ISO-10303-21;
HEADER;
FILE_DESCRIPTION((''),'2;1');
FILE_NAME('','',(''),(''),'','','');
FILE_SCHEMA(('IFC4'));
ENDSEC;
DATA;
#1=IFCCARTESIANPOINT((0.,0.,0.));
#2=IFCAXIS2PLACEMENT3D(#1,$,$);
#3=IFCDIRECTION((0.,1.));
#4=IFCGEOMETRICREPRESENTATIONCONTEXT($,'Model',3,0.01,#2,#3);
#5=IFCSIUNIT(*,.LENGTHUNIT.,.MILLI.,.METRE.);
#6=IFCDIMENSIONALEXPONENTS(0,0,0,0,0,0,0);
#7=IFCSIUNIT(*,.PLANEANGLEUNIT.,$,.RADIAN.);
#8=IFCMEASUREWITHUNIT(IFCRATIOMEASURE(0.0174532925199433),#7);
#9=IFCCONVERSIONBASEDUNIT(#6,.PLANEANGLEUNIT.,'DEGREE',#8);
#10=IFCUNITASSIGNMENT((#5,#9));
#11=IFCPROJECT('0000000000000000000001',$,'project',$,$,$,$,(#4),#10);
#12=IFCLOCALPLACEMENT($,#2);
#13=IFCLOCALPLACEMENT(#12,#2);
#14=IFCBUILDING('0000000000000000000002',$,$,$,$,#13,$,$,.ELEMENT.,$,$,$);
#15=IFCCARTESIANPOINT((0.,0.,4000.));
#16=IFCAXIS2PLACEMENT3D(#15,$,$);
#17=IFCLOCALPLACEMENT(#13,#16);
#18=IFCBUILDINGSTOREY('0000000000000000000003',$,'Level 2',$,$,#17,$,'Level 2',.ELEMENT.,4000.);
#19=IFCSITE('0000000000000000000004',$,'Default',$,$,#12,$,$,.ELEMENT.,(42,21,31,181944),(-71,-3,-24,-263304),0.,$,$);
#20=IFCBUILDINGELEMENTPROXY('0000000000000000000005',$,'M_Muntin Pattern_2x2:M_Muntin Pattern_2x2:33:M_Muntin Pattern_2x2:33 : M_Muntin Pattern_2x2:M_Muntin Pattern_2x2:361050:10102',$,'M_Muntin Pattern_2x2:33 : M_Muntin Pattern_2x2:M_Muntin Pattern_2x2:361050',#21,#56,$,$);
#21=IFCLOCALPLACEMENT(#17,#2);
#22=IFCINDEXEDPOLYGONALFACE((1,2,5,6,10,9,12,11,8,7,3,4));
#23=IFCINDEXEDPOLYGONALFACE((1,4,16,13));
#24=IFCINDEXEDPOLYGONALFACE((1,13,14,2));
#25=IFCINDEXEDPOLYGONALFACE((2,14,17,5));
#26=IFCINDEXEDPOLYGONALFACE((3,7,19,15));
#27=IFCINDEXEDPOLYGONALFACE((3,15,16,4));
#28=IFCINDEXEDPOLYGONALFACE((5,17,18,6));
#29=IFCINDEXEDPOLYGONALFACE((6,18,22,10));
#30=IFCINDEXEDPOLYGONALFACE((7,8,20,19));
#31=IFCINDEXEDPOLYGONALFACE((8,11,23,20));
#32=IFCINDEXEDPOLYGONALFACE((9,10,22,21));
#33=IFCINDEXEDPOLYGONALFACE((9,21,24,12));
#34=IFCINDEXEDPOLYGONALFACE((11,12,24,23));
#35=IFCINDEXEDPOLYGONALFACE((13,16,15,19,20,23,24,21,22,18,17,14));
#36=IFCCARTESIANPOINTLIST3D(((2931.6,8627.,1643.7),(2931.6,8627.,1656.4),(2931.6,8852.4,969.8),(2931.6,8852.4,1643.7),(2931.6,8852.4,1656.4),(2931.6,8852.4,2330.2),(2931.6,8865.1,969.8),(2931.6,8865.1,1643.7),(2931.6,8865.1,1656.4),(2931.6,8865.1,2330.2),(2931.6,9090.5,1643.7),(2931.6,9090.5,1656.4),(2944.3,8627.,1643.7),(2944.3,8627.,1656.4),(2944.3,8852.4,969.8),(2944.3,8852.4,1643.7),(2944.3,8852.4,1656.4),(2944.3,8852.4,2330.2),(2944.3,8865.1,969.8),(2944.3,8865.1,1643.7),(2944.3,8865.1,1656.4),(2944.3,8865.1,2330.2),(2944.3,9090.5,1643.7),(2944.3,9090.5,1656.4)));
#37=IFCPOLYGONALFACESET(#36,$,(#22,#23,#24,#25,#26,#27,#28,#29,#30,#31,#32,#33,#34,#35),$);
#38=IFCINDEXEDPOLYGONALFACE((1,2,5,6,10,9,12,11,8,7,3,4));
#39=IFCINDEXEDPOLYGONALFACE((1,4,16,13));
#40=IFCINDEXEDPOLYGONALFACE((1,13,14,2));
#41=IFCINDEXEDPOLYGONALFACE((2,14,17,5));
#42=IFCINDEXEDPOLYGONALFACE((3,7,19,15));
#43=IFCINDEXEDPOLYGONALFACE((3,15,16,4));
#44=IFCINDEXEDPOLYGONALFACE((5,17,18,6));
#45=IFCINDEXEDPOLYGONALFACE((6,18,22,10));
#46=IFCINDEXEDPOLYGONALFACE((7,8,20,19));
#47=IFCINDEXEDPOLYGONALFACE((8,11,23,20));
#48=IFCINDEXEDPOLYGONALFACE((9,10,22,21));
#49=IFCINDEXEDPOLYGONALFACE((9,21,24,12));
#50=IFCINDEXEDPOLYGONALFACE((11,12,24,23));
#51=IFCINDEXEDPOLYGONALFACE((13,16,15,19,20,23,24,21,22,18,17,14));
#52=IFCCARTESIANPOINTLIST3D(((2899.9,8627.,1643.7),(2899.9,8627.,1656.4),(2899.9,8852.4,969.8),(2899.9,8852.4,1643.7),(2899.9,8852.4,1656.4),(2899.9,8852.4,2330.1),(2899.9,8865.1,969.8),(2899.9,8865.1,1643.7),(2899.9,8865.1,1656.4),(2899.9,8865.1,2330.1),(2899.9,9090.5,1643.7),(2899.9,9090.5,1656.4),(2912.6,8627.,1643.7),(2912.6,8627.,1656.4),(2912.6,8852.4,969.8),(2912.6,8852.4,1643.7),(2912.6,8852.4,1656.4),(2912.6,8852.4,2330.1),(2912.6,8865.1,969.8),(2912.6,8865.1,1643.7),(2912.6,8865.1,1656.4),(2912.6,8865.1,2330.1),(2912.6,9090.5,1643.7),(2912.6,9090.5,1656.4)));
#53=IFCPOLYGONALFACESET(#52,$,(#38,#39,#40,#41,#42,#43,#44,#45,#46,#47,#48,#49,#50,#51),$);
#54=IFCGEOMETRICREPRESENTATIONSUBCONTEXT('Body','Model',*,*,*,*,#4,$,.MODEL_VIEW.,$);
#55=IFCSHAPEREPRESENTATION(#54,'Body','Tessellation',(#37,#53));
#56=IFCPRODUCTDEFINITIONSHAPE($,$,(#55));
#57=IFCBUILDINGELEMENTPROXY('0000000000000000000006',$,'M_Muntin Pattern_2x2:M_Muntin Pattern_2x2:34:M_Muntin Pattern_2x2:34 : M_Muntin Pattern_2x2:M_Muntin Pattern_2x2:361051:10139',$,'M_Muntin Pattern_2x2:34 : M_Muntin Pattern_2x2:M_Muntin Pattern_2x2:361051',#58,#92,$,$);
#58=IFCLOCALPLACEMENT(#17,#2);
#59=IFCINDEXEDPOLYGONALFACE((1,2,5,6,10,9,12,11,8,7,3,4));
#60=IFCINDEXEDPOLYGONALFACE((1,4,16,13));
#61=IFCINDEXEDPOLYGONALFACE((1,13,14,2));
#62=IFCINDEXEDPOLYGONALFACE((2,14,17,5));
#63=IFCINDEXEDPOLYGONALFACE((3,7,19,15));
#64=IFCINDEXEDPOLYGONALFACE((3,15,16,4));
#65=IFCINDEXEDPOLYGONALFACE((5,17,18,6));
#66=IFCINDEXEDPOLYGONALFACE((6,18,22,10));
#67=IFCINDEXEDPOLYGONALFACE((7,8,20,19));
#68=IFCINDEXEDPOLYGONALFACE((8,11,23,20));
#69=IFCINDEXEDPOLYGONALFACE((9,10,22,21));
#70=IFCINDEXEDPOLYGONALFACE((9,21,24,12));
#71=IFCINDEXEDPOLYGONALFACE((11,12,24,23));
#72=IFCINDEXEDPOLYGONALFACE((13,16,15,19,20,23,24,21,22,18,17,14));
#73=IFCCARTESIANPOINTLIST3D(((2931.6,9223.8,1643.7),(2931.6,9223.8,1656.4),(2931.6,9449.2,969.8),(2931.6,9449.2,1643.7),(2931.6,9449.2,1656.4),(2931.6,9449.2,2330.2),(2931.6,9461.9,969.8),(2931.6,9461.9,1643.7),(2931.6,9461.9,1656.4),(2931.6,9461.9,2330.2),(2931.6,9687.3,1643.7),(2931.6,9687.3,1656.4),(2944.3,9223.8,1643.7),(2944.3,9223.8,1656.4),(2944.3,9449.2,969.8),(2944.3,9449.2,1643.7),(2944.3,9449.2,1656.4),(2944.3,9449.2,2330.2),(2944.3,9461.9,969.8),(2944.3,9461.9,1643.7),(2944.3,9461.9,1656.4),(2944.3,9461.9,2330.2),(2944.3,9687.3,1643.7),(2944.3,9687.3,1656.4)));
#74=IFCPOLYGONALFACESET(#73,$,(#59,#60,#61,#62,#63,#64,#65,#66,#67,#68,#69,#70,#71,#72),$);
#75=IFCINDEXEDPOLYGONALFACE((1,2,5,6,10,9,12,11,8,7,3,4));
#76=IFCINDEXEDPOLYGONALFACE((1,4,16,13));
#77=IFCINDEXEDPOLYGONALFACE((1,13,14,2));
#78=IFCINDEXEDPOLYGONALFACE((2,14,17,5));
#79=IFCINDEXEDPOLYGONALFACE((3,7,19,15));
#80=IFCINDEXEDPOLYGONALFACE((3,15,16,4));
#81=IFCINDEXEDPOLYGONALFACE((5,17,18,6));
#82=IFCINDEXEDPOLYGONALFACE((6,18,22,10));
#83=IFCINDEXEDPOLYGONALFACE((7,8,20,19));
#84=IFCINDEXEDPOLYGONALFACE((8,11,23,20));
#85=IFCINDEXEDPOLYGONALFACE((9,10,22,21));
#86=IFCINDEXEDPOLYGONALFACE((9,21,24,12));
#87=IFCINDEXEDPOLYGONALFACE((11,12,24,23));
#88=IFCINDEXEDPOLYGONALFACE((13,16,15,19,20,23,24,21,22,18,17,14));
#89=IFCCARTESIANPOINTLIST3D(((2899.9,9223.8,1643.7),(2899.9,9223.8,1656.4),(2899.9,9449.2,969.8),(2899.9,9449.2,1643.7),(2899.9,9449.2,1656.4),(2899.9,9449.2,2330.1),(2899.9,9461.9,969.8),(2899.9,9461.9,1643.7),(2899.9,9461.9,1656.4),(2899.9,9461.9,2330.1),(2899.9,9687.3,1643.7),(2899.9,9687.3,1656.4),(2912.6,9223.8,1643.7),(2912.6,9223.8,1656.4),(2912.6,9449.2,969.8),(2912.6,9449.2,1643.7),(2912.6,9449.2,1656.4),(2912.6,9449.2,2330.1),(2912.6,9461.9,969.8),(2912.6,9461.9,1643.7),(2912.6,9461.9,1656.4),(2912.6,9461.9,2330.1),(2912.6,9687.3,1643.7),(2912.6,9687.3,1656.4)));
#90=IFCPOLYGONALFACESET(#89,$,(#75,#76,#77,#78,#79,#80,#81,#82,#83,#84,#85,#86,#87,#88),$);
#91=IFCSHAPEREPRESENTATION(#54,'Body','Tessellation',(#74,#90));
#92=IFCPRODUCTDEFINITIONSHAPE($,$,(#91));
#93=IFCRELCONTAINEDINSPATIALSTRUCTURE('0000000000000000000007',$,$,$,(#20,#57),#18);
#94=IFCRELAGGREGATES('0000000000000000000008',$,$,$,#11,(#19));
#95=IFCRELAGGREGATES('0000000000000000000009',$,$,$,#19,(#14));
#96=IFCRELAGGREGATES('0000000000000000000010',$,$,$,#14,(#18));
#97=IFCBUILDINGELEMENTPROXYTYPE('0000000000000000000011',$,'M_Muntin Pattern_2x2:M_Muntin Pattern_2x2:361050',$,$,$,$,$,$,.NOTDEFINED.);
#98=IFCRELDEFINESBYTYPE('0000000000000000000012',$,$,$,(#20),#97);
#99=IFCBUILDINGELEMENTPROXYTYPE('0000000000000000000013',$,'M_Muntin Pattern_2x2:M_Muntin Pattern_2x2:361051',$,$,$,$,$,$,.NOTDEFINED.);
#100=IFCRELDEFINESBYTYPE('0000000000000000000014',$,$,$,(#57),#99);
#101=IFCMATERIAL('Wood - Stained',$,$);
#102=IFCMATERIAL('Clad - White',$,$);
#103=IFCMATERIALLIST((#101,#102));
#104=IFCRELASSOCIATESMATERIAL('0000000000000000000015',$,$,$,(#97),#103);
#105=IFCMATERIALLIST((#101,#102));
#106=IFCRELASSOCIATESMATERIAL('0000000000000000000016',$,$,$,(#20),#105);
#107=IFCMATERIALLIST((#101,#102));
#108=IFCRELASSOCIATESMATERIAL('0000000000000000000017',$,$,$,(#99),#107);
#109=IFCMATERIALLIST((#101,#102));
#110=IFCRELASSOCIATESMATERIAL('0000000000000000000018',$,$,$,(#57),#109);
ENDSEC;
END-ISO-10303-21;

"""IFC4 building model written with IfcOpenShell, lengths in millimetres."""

from ifc_helpers import new_model, entity, si_unit, converted_unit, direction, frame, origin, place, context, subcontext, project, spatial, polyline, outline, extrude, source, transform, mapped, material, material_list, type_object, type_shapes, element, save


model = new_model("IFC4")

# Units and contexts
model_context = context("Model", 3, precision=0.01, world=origin(), true_north=direction((0.0, 1.0)))
body_context = subcontext(model_context, "Body", "Model", "MODEL_VIEW")
ifc_project = project(units=[si_unit("LENGTHUNIT", "METRE", prefix="MILLI"), converted_unit("PLANEANGLEUNIT", "DEGREE", entity("IfcRatioMeasure", 0.0174532925199433), si_unit("PLANEANGLEUNIT", "RADIAN"), dimensions=[0, 0, 0, 0, 0, 0, 0])], contexts=[model_context])

# Site, building, storey
site_placement = place(None, origin())
site = spatial("IfcSite", under=ifc_project, at=site_placement, Name="Default", CompositionType="ELEMENT", RefLatitude=(42, 21, 31, 181944), RefLongitude=(-71, -3, -24, -263304), RefElevation=0.0)
building_placement = place(site_placement, origin())
building = spatial("IfcBuilding", under=site, at=building_placement, CompositionType="ELEMENT")
storey_placement = place(building_placement, frame((0.0, 0.0, 4000.0)))
storey = spatial("IfcBuildingStorey", under=building, at=storey_placement, Name="Level 2", LongName="Level 2", CompositionType="ELEMENT", Elevation=4000.0)

# Building element proxies
ifc_material_1 = material(Name="Wood - Stained")
ifc_material_2 = material(Name="Clad - White")
ifc_material_list_1 = material_list([ifc_material_1, ifc_material_2])
ifc_material_list_2 = material_list([ifc_material_1, ifc_material_2])
building_element_proxy_type_1 = type_object("IfcBuildingElementProxyType", Name="M_Muntin Pattern_2x2:M_Muntin Pattern_2x2:361050", PredefinedType="NOTDEFINED", material=ifc_material_list_2)
shared_shape_1 = source(origin(), body_context, "Body", "SweptSolid", [
    extrude(outline(polyline([(-680.2, 6.4), (-680.2, -6.3), (-6.4, -6.3), (-6.4, -231.7), (6.3, -231.7), (6.3, -6.3), (680.2, -6.3), (680.2, 6.4), (6.3, 6.4), (6.3, 231.7), (-6.4, 231.7), (-6.4, 6.4), (-680.2, 6.4)])), frame((2931.6, 8858.7, 5650.0), z_axis=(-1.0, 0.0, 0.0), x_axis=(0.0, 0.0, -1.0)), (0.0, 0.0, -1.0), 12.7),
    extrude(outline(polyline([(-680.1, 6.4), (-680.1, -6.3), (-6.4, -6.3), (-6.4, -231.7), (6.3, -231.7), (6.3, -6.3), (680.2, -6.3), (680.2, 6.4), (6.3, 6.4), (6.3, 231.7), (-6.4, 231.7), (-6.4, 6.4), (-680.1, 6.4)])), frame((2899.9, 8858.7, 5650.0), z_axis=(-1.0, 0.0, 0.0), x_axis=(0.0, 0.0, -1.0)), (0.0, 0.0, -1.0), 12.7),
])
type_shapes(building_element_proxy_type_1, [shared_shape_1])
proxy_1_placement = place(storey_placement, frame((0.0, 0.0, -4000.0)))
element("IfcBuildingElementProxy", 1, at=proxy_1_placement, inside=storey, type_object=building_element_proxy_type_1, material=ifc_material_list_1, Name="M_Muntin Pattern_2x2:M_Muntin Pattern_2x2:33:M_Muntin Pattern_2x2:33 : M_Muntin Pattern_2x2:M_Muntin Pattern_2x2:361050:10102", ObjectType="M_Muntin Pattern_2x2:33 : M_Muntin Pattern_2x2:M_Muntin Pattern_2x2:361050", context=body_context, shape_type="MappedRepresentation", body=[
    mapped(shared_shape_1, transform((0.0, 0.0, 0.0), scale=1.0)),
])
ifc_material_list_3 = material_list([ifc_material_1, ifc_material_2])
ifc_material_list_4 = material_list([ifc_material_1, ifc_material_2])
building_element_proxy_type_2 = type_object("IfcBuildingElementProxyType", Name="M_Muntin Pattern_2x2:M_Muntin Pattern_2x2:361051", PredefinedType="NOTDEFINED", material=ifc_material_list_4)
shared_shape_2 = source(origin(), body_context, "Body", "SweptSolid", [
    extrude(outline(polyline([(-6.4, -680.1), (6.3, -680.1), (6.3, -6.4), (231.7, -6.4), (231.7, 6.3), (6.3, 6.3), (6.3, 680.2), (-6.4, 680.2), (-6.4, 6.3), (-231.7, 6.3), (-231.7, -6.4), (-6.4, -6.4), (-6.4, -680.1)])), frame((2931.6, 9455.6, 5650.0), z_axis=(1.0, 0.0, 0.0), x_axis=(0.0, -1.0, 0.0)), (0.0, 0.0, 1.0), 12.7),
    extrude(outline(polyline([(-6.4, -680.1), (6.3, -680.1), (6.3, -6.4), (231.7, -6.4), (231.7, 6.3), (6.3, 6.3), (6.3, 680.2), (-6.4, 680.2), (-6.4, 6.3), (-231.7, 6.3), (-231.7, -6.4), (-6.4, -6.4), (-6.4, -680.1)])), frame((2899.9, 9455.6, 5650.0), z_axis=(1.0, 0.0, 0.0), x_axis=(0.0, -1.0, 0.0)), (0.0, 0.0, 1.0), 12.7),
])
type_shapes(building_element_proxy_type_2, [shared_shape_2])
proxy_2_placement = place(storey_placement, frame((0.0, 0.0, -4000.0)))
element("IfcBuildingElementProxy", 2, at=proxy_2_placement, inside=storey, type_object=building_element_proxy_type_2, material=ifc_material_list_3, Name="M_Muntin Pattern_2x2:M_Muntin Pattern_2x2:34:M_Muntin Pattern_2x2:34 : M_Muntin Pattern_2x2:M_Muntin Pattern_2x2:361051:10139", ObjectType="M_Muntin Pattern_2x2:34 : M_Muntin Pattern_2x2:M_Muntin Pattern_2x2:361051", context=body_context, shape_type="MappedRepresentation", body=[
    mapped(shared_shape_2, transform((0.0, 0.0, 0.0), scale=1.0)),
])

save(model, "model.ifc")
